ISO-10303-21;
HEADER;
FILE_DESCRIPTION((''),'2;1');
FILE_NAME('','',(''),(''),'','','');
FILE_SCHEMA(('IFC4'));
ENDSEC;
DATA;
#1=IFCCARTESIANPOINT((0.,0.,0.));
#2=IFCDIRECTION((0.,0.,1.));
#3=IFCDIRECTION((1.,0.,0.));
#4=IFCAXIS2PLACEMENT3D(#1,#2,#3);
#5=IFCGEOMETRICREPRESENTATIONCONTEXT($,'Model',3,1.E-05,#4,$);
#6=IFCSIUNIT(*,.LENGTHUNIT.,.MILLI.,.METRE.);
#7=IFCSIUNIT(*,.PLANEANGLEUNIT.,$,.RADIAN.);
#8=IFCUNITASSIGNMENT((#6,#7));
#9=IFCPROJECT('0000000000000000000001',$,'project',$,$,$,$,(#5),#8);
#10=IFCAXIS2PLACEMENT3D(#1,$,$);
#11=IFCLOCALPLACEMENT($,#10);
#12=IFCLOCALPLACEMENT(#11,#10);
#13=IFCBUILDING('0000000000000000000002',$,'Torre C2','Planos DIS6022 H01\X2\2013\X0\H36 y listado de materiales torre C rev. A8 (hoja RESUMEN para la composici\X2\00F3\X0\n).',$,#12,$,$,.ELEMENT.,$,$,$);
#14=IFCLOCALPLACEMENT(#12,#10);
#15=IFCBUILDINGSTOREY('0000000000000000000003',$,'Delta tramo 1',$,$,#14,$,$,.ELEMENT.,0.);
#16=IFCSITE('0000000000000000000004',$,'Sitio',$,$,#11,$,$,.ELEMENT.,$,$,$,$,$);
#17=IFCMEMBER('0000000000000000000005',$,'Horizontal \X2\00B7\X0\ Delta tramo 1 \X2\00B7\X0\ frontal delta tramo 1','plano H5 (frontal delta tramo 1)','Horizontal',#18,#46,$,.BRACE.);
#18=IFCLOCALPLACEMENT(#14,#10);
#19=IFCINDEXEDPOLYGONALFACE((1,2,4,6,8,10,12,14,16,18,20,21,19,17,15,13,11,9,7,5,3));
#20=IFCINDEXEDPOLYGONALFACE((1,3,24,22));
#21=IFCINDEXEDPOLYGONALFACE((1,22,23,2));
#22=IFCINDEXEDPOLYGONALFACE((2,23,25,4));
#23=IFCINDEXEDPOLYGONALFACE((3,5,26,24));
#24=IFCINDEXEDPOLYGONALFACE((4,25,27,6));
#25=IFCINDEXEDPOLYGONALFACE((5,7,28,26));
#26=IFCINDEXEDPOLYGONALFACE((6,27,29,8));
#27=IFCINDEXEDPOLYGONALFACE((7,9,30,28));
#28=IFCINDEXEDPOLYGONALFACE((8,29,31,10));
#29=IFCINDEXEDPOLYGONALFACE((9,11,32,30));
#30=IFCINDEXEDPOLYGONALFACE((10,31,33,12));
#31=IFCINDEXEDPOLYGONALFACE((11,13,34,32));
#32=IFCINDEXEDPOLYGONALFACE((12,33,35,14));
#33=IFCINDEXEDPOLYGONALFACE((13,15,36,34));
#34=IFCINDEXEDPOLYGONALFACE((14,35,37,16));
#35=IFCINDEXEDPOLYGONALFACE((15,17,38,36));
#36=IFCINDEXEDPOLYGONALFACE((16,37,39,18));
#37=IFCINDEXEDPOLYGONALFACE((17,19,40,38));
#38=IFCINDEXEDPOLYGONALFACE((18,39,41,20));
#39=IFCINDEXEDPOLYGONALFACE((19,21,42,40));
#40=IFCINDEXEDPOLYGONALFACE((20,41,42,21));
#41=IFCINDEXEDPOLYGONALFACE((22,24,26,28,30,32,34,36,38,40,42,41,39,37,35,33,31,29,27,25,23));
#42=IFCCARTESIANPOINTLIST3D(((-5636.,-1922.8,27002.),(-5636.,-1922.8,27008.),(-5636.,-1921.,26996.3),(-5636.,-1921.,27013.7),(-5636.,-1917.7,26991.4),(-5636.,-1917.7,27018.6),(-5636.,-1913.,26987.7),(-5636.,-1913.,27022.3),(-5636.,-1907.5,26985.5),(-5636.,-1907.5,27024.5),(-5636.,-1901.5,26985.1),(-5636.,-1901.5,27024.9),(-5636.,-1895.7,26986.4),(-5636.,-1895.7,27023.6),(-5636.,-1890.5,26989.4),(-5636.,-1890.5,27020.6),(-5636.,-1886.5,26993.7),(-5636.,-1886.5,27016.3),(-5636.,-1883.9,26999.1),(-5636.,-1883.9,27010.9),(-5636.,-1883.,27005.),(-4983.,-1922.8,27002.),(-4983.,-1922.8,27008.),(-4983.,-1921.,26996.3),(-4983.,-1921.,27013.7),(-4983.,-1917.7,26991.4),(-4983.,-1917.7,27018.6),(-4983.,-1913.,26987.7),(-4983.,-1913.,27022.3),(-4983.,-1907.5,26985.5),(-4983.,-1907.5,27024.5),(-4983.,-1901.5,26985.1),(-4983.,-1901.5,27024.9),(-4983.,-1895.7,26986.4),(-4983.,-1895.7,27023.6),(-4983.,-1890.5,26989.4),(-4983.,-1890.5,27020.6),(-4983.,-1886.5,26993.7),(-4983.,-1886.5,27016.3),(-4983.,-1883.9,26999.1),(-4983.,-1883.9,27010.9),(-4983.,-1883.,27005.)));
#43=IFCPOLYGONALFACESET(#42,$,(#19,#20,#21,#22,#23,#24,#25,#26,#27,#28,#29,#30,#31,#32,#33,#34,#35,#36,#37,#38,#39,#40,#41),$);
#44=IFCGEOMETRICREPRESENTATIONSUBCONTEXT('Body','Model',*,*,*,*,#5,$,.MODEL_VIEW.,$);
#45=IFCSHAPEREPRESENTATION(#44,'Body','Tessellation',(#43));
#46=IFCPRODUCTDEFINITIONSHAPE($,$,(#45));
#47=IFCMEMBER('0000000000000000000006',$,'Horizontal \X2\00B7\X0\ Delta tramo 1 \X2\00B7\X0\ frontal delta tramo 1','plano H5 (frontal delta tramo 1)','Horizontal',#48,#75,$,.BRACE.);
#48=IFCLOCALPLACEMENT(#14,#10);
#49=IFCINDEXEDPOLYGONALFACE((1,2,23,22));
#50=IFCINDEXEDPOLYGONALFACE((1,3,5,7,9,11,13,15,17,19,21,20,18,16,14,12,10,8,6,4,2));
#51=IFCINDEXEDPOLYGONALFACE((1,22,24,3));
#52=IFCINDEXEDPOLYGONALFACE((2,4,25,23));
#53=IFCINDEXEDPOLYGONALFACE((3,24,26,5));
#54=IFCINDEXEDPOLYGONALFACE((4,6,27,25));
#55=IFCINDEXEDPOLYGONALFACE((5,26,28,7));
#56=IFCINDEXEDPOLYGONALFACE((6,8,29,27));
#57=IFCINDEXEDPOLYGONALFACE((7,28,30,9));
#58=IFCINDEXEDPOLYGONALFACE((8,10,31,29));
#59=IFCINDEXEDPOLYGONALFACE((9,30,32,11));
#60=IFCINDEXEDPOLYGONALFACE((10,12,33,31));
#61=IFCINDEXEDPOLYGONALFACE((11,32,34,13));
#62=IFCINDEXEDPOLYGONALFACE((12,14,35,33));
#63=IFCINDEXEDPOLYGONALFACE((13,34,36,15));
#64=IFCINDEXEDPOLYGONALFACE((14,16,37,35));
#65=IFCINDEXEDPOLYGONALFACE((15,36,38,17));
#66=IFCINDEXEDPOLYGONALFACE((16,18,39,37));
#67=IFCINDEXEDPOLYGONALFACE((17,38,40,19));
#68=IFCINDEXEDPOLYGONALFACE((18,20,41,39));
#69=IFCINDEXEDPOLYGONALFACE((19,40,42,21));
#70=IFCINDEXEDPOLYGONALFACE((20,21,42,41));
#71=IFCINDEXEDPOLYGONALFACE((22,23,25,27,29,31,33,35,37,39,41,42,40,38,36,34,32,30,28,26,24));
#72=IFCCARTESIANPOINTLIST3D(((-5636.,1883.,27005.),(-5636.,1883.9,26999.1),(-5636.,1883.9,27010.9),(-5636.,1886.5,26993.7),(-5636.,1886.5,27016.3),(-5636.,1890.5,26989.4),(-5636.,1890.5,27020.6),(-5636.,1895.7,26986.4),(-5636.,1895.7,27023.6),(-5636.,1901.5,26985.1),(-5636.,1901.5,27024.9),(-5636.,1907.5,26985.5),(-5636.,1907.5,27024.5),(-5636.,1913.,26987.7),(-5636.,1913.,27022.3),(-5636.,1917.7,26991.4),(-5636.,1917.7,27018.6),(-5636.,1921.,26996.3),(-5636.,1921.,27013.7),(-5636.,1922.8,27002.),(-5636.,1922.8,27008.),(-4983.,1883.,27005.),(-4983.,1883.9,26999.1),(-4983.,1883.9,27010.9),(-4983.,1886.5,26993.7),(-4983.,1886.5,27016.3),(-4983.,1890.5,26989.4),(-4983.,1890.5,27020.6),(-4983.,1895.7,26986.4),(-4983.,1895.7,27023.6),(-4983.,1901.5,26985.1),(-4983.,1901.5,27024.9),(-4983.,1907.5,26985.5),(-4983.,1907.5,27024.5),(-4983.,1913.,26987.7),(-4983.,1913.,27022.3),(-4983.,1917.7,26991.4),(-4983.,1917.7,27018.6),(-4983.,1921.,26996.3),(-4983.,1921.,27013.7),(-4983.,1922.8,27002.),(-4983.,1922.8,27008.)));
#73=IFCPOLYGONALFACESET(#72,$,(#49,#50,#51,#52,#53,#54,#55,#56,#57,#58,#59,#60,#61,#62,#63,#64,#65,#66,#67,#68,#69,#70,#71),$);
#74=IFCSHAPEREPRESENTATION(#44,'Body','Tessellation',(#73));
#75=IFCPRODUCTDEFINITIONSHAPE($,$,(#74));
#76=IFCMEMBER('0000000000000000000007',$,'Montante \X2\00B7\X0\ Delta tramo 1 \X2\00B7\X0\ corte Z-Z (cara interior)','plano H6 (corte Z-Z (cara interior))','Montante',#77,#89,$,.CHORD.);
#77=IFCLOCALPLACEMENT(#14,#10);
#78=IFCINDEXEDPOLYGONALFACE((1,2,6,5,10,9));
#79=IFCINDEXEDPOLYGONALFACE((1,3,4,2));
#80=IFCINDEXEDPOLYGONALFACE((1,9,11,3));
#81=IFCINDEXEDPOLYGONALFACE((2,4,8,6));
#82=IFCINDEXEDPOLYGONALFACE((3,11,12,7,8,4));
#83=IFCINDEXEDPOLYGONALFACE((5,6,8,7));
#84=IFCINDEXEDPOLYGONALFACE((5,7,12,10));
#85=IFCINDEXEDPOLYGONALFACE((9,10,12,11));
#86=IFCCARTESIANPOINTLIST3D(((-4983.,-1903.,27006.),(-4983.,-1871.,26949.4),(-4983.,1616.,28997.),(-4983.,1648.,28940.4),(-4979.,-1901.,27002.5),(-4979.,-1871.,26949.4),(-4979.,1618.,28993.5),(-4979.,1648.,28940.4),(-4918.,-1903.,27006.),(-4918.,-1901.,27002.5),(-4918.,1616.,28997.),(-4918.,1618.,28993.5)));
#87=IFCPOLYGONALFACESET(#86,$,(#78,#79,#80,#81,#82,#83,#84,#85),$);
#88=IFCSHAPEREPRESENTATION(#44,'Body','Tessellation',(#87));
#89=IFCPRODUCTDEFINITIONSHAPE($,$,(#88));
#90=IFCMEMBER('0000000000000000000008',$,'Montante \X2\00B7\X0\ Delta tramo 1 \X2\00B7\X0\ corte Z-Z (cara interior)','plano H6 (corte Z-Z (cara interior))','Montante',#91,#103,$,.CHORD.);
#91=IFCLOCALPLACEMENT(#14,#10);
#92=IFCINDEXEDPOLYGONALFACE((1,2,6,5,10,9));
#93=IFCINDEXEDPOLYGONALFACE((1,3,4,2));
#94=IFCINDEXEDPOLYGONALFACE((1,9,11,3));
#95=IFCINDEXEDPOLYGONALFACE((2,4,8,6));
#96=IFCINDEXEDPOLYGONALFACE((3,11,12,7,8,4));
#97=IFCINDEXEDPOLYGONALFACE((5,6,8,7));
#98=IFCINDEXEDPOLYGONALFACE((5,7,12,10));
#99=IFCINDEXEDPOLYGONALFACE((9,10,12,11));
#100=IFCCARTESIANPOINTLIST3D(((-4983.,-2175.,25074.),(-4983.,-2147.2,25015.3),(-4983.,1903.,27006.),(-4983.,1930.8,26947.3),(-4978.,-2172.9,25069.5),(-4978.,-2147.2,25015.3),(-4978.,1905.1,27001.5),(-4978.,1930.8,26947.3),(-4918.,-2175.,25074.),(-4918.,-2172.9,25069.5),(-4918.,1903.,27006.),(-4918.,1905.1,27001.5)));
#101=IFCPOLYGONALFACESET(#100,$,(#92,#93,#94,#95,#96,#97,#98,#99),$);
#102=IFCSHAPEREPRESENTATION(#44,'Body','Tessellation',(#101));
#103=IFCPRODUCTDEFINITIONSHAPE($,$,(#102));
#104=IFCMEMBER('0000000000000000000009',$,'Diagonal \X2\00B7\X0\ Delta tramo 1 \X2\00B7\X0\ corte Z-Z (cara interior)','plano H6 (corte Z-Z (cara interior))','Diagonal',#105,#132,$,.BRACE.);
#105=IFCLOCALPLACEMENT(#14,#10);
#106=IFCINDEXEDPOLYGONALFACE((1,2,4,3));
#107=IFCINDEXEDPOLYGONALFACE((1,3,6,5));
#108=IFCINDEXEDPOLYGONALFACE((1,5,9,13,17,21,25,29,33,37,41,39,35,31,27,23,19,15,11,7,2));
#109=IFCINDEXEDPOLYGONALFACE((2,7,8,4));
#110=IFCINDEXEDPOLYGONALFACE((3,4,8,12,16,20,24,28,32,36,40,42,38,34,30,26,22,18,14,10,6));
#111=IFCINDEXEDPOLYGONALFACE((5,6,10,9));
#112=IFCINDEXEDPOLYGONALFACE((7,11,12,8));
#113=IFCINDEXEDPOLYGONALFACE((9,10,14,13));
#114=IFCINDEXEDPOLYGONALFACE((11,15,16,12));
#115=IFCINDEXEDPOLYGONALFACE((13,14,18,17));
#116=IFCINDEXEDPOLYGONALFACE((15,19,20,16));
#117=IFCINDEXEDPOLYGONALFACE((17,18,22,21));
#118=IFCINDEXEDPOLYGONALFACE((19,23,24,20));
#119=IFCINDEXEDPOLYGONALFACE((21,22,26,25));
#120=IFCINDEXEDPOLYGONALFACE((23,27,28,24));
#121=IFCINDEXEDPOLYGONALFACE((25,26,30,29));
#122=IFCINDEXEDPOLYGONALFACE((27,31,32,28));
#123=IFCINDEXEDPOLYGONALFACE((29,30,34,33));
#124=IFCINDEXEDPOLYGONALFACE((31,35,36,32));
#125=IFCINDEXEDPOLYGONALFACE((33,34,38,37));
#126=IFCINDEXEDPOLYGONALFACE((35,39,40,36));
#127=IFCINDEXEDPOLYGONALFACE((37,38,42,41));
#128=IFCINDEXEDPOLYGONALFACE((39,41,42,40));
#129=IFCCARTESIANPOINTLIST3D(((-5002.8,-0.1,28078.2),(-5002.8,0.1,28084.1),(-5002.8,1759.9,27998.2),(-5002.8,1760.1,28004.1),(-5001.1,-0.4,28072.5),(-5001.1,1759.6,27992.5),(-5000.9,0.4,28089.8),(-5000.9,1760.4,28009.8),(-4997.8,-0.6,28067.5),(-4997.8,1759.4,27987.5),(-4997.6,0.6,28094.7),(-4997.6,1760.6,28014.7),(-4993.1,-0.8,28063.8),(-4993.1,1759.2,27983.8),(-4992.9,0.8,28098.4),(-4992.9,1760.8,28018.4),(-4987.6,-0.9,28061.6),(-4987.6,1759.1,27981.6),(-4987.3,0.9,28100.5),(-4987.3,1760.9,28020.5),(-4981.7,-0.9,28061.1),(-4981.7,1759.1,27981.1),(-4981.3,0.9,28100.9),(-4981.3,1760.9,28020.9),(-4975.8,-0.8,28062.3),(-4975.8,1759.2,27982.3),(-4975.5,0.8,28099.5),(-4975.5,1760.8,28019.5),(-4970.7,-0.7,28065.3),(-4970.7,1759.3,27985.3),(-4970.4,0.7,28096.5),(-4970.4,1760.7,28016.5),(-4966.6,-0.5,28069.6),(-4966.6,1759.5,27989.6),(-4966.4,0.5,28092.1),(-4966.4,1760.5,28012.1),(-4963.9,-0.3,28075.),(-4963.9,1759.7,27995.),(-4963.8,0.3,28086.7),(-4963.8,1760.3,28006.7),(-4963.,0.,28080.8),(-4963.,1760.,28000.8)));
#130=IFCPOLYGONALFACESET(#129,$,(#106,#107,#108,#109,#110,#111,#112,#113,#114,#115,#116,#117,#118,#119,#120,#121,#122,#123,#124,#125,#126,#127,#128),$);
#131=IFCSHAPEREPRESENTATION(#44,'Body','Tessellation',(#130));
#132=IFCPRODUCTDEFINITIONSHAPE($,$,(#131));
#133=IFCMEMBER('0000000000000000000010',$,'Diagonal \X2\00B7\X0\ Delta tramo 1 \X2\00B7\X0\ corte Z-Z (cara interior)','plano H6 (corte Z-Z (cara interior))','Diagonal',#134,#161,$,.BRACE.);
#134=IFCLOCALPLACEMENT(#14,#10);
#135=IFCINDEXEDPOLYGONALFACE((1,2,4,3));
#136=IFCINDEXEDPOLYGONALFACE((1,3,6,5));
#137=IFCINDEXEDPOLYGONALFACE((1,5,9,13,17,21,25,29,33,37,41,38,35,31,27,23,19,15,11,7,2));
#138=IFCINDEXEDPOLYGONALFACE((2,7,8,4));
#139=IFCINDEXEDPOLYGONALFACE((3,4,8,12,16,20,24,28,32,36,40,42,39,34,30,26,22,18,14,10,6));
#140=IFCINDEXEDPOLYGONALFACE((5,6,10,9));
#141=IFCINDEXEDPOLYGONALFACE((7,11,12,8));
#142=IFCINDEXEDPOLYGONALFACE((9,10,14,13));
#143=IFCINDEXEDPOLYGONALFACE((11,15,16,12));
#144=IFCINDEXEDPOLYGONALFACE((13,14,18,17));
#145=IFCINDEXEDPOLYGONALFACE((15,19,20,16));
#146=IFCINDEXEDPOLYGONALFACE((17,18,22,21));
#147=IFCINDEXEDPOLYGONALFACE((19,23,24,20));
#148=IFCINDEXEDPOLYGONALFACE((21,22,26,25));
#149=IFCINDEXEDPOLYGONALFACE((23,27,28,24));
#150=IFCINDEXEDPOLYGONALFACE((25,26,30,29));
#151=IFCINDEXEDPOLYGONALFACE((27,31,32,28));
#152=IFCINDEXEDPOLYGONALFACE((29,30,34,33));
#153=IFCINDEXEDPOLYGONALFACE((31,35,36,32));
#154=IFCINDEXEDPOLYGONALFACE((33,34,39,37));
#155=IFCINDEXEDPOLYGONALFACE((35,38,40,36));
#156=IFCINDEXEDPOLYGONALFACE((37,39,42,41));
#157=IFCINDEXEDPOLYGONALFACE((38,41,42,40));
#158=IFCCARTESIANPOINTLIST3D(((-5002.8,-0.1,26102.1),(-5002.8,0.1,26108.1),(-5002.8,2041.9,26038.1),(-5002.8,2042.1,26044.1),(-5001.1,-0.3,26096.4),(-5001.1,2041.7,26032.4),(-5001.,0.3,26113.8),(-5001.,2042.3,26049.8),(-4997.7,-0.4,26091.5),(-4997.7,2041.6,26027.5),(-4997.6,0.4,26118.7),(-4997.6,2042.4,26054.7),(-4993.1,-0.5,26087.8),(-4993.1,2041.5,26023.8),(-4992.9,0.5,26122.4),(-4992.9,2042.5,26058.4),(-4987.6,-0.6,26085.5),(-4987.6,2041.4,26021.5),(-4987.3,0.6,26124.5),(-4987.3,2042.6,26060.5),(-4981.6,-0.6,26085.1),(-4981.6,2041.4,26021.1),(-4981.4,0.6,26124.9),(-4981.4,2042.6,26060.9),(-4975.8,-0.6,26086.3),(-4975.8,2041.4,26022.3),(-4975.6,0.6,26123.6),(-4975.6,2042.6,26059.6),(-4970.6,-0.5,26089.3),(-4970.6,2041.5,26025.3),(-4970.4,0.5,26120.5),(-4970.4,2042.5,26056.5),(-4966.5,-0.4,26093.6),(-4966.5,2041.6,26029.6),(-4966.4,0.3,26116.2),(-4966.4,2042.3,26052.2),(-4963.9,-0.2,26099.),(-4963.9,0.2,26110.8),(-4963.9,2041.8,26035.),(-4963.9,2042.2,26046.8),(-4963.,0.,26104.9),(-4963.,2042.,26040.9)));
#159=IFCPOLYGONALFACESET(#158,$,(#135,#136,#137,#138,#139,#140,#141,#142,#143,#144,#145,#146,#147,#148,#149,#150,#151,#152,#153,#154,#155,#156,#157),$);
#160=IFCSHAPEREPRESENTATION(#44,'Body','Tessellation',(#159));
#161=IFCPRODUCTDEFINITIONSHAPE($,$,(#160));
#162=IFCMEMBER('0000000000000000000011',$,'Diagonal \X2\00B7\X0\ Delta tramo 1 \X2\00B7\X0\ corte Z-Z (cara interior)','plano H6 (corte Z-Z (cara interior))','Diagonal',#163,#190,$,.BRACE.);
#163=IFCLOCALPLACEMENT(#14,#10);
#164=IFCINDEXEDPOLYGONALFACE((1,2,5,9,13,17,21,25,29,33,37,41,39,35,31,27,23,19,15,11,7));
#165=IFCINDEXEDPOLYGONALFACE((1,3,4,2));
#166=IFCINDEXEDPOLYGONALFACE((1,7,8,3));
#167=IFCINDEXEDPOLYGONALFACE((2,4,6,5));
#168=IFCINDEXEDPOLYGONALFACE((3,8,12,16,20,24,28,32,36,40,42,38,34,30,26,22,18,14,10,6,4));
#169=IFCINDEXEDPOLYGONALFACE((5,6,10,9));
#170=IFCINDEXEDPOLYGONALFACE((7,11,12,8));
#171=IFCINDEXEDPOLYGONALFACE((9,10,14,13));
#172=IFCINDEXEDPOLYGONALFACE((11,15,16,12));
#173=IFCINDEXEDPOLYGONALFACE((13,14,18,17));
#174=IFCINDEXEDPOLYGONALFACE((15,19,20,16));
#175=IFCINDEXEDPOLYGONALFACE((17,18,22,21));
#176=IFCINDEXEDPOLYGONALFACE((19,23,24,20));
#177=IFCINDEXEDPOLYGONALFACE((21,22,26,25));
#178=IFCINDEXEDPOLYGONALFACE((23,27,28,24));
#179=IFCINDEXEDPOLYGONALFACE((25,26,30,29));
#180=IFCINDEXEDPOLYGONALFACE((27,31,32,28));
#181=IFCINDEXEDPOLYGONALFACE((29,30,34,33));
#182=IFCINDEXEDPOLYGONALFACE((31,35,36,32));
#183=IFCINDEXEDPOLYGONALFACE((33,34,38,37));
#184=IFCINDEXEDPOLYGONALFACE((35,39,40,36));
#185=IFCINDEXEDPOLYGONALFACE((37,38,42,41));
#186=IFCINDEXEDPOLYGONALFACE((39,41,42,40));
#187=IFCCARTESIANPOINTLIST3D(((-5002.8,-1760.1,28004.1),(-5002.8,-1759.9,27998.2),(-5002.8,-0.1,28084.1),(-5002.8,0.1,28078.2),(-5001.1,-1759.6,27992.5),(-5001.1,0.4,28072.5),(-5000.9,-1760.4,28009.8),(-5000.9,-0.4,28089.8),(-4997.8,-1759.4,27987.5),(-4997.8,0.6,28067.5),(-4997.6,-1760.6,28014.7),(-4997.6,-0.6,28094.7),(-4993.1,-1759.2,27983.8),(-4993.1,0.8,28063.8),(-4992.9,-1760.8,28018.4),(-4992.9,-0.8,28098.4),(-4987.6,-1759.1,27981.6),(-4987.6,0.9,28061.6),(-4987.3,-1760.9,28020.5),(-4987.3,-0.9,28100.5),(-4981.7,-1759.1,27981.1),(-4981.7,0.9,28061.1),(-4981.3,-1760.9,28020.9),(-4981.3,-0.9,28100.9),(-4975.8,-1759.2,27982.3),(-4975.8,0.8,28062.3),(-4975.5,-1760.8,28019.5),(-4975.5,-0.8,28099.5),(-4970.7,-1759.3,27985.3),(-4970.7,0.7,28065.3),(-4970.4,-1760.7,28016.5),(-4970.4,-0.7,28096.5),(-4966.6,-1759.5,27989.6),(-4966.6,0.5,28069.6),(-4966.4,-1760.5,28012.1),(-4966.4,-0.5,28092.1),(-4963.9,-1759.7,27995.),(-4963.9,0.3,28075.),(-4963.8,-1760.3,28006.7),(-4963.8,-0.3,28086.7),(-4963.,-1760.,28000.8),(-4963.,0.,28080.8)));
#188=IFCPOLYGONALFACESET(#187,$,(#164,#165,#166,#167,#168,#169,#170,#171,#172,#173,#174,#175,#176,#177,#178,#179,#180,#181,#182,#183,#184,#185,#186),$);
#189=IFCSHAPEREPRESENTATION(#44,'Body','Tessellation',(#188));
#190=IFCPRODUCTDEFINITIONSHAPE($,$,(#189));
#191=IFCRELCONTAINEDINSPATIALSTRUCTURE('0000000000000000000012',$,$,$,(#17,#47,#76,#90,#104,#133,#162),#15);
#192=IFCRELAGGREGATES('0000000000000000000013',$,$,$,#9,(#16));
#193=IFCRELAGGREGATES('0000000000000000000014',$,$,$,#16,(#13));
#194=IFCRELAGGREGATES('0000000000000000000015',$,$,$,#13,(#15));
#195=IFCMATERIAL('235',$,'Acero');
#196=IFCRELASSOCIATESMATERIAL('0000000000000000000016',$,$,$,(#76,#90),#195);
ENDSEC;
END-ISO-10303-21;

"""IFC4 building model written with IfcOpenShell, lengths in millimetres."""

from ifc_helpers import new_model, si_unit, frame, frame_2d, origin, origin_with_axes, place, context, subcontext, project, spatial, circle, l_section, extrude, material, element, save


model = new_model("IFC4")

# Units and contexts
model_context = context("Model", 3, precision=1e-05, world=origin_with_axes())
body_context = subcontext(model_context, "Body", "Model", "MODEL_VIEW")
ifc_project = project(units=[si_unit("LENGTHUNIT", "METRE", prefix="MILLI"), si_unit("PLANEANGLEUNIT", "RADIAN")], contexts=[model_context])

# Site, building, storey
site_placement = place(None, origin())
site = spatial("IfcSite", under=ifc_project, at=site_placement, Name="Sitio", CompositionType="ELEMENT")
building_placement = place(site_placement, origin())
building = spatial("IfcBuilding", under=site, at=building_placement, Name="Torre C2", Description="Planos DIS6022 H01–H36 y listado de materiales torre C rev. A8 (hoja RESUMEN para la composición).", CompositionType="ELEMENT")
storey_placement = place(building_placement, origin())
storey = spatial("IfcBuildingStorey", under=building, at=storey_placement, Name="Delta tramo 1", CompositionType="ELEMENT", Elevation=0.0)

# Members
for number, where, z_axis, x_axis, name in (
    (1, (-5636.0, -1903.0, 27005.0), (1.0, 0.0, 0.0), (0.0, 1.0, 0.0), "Horizontal · Delta tramo 1 · frontal delta tramo 1"),
    (2, (-5636.0, 1903.0, 27005.0), (1.0, 0.0, 0.0), (0.0, -1.0, 0.0), "Horizontal · Delta tramo 1 · frontal delta tramo 1"),
):
    element("IfcMember", number, at=place(storey_placement, frame(where, z_axis=z_axis, x_axis=x_axis)), inside=storey, Name=name, Description="plano H5 (frontal delta tramo 1)", ObjectType="Horizontal", PredefinedType="BRACE", context=body_context, shape_type="SweptSolid", body=[
        extrude(circle(Radius=20.0), None, (0.0, 0.0, 1.0), 653.0),
    ])
ifc_material_1 = material(Name="235", Category="Acero")
member_1_placement = place(storey_placement, frame((-4983.0, -1903.0, 27006.0), z_axis=(0.0, 0.870351, 0.492432), x_axis=(1.0, 0.0, 0.0)))
element("IfcMember", 3, at=member_1_placement, inside=storey, material=ifc_material_1, Name="Montante · Delta tramo 1 · corte Z-Z (cara interior)", Description="plano H6 (corte Z-Z (cara interior))", ObjectType="Montante", PredefinedType="CHORD", context=body_context, shape_type="SweptSolid", body=[
    extrude(l_section(Depth=65.0, Width=65.0, Thickness=4.0, at=frame_2d((32.5, 32.5))), None, (0.0, 0.0, 1.0), 4043.2),
])
member_2_placement = place(storey_placement, frame((-4983.0, 1903.0, 27006.0), z_axis=(0.0, -0.903711, -0.428144), x_axis=(0.0, 0.428144, -0.903711)))
element("IfcMember", 4, at=member_2_placement, inside=storey, material=ifc_material_1, Name="Montante · Delta tramo 1 · corte Z-Z (cara interior)", Description="plano H6 (corte Z-Z (cara interior))", ObjectType="Montante", PredefinedType="CHORD", context=body_context, shape_type="SweptSolid", body=[
    extrude(l_section(Depth=65.0, Width=65.0, Thickness=5.0, at=frame_2d((32.5, 32.5))), None, (0.0, 0.0, 1.0), 4512.5),
])
member_3_placement = place(storey_placement, frame((-4983.0, 1760.0, 28001.0), z_axis=(0.0, -0.998969, 0.045408), x_axis=(0.999968, -0.000364, -0.00801)))
element("IfcMember", 5, at=member_3_placement, inside=storey, Name="Diagonal · Delta tramo 1 · corte Z-Z (cara interior)", Description="plano H6 (corte Z-Z (cara interior))", ObjectType="Diagonal", PredefinedType="BRACE", context=body_context, shape_type="SweptSolid", body=[
    extrude(circle(Radius=20.0), None, (0.0, 0.0, 1.0), 1761.8),
])
member_4_placement = place(storey_placement, frame((-4983.0, 2042.0, 26041.0), z_axis=(0.0, -0.999509, 0.031326), x_axis=(0.999979, -0.000201, -0.006415)))
element("IfcMember", 6, at=member_4_placement, inside=storey, Name="Diagonal · Delta tramo 1 · corte Z-Z (cara interior)", Description="plano H6 (corte Z-Z (cara interior))", ObjectType="Diagonal", PredefinedType="BRACE", context=body_context, shape_type="SweptSolid", body=[
    extrude(circle(Radius=20.0), None, (0.0, 0.0, 1.0), 2043.0),
])
member_5_placement = place(storey_placement, frame((-4983.0, -1760.0, 28001.0), z_axis=(0.0, 0.998969, 0.045408), x_axis=(0.999968, 0.000364, -0.00801)))
element("IfcMember", 7, at=member_5_placement, inside=storey, Name="Diagonal · Delta tramo 1 · corte Z-Z (cara interior)", Description="plano H6 (corte Z-Z (cara interior))", ObjectType="Diagonal", PredefinedType="BRACE", context=body_context, shape_type="SweptSolid", body=[
    extrude(circle(Radius=20.0), None, (0.0, 0.0, 1.0), 1761.8),
])

save(model, "model.ifc")
